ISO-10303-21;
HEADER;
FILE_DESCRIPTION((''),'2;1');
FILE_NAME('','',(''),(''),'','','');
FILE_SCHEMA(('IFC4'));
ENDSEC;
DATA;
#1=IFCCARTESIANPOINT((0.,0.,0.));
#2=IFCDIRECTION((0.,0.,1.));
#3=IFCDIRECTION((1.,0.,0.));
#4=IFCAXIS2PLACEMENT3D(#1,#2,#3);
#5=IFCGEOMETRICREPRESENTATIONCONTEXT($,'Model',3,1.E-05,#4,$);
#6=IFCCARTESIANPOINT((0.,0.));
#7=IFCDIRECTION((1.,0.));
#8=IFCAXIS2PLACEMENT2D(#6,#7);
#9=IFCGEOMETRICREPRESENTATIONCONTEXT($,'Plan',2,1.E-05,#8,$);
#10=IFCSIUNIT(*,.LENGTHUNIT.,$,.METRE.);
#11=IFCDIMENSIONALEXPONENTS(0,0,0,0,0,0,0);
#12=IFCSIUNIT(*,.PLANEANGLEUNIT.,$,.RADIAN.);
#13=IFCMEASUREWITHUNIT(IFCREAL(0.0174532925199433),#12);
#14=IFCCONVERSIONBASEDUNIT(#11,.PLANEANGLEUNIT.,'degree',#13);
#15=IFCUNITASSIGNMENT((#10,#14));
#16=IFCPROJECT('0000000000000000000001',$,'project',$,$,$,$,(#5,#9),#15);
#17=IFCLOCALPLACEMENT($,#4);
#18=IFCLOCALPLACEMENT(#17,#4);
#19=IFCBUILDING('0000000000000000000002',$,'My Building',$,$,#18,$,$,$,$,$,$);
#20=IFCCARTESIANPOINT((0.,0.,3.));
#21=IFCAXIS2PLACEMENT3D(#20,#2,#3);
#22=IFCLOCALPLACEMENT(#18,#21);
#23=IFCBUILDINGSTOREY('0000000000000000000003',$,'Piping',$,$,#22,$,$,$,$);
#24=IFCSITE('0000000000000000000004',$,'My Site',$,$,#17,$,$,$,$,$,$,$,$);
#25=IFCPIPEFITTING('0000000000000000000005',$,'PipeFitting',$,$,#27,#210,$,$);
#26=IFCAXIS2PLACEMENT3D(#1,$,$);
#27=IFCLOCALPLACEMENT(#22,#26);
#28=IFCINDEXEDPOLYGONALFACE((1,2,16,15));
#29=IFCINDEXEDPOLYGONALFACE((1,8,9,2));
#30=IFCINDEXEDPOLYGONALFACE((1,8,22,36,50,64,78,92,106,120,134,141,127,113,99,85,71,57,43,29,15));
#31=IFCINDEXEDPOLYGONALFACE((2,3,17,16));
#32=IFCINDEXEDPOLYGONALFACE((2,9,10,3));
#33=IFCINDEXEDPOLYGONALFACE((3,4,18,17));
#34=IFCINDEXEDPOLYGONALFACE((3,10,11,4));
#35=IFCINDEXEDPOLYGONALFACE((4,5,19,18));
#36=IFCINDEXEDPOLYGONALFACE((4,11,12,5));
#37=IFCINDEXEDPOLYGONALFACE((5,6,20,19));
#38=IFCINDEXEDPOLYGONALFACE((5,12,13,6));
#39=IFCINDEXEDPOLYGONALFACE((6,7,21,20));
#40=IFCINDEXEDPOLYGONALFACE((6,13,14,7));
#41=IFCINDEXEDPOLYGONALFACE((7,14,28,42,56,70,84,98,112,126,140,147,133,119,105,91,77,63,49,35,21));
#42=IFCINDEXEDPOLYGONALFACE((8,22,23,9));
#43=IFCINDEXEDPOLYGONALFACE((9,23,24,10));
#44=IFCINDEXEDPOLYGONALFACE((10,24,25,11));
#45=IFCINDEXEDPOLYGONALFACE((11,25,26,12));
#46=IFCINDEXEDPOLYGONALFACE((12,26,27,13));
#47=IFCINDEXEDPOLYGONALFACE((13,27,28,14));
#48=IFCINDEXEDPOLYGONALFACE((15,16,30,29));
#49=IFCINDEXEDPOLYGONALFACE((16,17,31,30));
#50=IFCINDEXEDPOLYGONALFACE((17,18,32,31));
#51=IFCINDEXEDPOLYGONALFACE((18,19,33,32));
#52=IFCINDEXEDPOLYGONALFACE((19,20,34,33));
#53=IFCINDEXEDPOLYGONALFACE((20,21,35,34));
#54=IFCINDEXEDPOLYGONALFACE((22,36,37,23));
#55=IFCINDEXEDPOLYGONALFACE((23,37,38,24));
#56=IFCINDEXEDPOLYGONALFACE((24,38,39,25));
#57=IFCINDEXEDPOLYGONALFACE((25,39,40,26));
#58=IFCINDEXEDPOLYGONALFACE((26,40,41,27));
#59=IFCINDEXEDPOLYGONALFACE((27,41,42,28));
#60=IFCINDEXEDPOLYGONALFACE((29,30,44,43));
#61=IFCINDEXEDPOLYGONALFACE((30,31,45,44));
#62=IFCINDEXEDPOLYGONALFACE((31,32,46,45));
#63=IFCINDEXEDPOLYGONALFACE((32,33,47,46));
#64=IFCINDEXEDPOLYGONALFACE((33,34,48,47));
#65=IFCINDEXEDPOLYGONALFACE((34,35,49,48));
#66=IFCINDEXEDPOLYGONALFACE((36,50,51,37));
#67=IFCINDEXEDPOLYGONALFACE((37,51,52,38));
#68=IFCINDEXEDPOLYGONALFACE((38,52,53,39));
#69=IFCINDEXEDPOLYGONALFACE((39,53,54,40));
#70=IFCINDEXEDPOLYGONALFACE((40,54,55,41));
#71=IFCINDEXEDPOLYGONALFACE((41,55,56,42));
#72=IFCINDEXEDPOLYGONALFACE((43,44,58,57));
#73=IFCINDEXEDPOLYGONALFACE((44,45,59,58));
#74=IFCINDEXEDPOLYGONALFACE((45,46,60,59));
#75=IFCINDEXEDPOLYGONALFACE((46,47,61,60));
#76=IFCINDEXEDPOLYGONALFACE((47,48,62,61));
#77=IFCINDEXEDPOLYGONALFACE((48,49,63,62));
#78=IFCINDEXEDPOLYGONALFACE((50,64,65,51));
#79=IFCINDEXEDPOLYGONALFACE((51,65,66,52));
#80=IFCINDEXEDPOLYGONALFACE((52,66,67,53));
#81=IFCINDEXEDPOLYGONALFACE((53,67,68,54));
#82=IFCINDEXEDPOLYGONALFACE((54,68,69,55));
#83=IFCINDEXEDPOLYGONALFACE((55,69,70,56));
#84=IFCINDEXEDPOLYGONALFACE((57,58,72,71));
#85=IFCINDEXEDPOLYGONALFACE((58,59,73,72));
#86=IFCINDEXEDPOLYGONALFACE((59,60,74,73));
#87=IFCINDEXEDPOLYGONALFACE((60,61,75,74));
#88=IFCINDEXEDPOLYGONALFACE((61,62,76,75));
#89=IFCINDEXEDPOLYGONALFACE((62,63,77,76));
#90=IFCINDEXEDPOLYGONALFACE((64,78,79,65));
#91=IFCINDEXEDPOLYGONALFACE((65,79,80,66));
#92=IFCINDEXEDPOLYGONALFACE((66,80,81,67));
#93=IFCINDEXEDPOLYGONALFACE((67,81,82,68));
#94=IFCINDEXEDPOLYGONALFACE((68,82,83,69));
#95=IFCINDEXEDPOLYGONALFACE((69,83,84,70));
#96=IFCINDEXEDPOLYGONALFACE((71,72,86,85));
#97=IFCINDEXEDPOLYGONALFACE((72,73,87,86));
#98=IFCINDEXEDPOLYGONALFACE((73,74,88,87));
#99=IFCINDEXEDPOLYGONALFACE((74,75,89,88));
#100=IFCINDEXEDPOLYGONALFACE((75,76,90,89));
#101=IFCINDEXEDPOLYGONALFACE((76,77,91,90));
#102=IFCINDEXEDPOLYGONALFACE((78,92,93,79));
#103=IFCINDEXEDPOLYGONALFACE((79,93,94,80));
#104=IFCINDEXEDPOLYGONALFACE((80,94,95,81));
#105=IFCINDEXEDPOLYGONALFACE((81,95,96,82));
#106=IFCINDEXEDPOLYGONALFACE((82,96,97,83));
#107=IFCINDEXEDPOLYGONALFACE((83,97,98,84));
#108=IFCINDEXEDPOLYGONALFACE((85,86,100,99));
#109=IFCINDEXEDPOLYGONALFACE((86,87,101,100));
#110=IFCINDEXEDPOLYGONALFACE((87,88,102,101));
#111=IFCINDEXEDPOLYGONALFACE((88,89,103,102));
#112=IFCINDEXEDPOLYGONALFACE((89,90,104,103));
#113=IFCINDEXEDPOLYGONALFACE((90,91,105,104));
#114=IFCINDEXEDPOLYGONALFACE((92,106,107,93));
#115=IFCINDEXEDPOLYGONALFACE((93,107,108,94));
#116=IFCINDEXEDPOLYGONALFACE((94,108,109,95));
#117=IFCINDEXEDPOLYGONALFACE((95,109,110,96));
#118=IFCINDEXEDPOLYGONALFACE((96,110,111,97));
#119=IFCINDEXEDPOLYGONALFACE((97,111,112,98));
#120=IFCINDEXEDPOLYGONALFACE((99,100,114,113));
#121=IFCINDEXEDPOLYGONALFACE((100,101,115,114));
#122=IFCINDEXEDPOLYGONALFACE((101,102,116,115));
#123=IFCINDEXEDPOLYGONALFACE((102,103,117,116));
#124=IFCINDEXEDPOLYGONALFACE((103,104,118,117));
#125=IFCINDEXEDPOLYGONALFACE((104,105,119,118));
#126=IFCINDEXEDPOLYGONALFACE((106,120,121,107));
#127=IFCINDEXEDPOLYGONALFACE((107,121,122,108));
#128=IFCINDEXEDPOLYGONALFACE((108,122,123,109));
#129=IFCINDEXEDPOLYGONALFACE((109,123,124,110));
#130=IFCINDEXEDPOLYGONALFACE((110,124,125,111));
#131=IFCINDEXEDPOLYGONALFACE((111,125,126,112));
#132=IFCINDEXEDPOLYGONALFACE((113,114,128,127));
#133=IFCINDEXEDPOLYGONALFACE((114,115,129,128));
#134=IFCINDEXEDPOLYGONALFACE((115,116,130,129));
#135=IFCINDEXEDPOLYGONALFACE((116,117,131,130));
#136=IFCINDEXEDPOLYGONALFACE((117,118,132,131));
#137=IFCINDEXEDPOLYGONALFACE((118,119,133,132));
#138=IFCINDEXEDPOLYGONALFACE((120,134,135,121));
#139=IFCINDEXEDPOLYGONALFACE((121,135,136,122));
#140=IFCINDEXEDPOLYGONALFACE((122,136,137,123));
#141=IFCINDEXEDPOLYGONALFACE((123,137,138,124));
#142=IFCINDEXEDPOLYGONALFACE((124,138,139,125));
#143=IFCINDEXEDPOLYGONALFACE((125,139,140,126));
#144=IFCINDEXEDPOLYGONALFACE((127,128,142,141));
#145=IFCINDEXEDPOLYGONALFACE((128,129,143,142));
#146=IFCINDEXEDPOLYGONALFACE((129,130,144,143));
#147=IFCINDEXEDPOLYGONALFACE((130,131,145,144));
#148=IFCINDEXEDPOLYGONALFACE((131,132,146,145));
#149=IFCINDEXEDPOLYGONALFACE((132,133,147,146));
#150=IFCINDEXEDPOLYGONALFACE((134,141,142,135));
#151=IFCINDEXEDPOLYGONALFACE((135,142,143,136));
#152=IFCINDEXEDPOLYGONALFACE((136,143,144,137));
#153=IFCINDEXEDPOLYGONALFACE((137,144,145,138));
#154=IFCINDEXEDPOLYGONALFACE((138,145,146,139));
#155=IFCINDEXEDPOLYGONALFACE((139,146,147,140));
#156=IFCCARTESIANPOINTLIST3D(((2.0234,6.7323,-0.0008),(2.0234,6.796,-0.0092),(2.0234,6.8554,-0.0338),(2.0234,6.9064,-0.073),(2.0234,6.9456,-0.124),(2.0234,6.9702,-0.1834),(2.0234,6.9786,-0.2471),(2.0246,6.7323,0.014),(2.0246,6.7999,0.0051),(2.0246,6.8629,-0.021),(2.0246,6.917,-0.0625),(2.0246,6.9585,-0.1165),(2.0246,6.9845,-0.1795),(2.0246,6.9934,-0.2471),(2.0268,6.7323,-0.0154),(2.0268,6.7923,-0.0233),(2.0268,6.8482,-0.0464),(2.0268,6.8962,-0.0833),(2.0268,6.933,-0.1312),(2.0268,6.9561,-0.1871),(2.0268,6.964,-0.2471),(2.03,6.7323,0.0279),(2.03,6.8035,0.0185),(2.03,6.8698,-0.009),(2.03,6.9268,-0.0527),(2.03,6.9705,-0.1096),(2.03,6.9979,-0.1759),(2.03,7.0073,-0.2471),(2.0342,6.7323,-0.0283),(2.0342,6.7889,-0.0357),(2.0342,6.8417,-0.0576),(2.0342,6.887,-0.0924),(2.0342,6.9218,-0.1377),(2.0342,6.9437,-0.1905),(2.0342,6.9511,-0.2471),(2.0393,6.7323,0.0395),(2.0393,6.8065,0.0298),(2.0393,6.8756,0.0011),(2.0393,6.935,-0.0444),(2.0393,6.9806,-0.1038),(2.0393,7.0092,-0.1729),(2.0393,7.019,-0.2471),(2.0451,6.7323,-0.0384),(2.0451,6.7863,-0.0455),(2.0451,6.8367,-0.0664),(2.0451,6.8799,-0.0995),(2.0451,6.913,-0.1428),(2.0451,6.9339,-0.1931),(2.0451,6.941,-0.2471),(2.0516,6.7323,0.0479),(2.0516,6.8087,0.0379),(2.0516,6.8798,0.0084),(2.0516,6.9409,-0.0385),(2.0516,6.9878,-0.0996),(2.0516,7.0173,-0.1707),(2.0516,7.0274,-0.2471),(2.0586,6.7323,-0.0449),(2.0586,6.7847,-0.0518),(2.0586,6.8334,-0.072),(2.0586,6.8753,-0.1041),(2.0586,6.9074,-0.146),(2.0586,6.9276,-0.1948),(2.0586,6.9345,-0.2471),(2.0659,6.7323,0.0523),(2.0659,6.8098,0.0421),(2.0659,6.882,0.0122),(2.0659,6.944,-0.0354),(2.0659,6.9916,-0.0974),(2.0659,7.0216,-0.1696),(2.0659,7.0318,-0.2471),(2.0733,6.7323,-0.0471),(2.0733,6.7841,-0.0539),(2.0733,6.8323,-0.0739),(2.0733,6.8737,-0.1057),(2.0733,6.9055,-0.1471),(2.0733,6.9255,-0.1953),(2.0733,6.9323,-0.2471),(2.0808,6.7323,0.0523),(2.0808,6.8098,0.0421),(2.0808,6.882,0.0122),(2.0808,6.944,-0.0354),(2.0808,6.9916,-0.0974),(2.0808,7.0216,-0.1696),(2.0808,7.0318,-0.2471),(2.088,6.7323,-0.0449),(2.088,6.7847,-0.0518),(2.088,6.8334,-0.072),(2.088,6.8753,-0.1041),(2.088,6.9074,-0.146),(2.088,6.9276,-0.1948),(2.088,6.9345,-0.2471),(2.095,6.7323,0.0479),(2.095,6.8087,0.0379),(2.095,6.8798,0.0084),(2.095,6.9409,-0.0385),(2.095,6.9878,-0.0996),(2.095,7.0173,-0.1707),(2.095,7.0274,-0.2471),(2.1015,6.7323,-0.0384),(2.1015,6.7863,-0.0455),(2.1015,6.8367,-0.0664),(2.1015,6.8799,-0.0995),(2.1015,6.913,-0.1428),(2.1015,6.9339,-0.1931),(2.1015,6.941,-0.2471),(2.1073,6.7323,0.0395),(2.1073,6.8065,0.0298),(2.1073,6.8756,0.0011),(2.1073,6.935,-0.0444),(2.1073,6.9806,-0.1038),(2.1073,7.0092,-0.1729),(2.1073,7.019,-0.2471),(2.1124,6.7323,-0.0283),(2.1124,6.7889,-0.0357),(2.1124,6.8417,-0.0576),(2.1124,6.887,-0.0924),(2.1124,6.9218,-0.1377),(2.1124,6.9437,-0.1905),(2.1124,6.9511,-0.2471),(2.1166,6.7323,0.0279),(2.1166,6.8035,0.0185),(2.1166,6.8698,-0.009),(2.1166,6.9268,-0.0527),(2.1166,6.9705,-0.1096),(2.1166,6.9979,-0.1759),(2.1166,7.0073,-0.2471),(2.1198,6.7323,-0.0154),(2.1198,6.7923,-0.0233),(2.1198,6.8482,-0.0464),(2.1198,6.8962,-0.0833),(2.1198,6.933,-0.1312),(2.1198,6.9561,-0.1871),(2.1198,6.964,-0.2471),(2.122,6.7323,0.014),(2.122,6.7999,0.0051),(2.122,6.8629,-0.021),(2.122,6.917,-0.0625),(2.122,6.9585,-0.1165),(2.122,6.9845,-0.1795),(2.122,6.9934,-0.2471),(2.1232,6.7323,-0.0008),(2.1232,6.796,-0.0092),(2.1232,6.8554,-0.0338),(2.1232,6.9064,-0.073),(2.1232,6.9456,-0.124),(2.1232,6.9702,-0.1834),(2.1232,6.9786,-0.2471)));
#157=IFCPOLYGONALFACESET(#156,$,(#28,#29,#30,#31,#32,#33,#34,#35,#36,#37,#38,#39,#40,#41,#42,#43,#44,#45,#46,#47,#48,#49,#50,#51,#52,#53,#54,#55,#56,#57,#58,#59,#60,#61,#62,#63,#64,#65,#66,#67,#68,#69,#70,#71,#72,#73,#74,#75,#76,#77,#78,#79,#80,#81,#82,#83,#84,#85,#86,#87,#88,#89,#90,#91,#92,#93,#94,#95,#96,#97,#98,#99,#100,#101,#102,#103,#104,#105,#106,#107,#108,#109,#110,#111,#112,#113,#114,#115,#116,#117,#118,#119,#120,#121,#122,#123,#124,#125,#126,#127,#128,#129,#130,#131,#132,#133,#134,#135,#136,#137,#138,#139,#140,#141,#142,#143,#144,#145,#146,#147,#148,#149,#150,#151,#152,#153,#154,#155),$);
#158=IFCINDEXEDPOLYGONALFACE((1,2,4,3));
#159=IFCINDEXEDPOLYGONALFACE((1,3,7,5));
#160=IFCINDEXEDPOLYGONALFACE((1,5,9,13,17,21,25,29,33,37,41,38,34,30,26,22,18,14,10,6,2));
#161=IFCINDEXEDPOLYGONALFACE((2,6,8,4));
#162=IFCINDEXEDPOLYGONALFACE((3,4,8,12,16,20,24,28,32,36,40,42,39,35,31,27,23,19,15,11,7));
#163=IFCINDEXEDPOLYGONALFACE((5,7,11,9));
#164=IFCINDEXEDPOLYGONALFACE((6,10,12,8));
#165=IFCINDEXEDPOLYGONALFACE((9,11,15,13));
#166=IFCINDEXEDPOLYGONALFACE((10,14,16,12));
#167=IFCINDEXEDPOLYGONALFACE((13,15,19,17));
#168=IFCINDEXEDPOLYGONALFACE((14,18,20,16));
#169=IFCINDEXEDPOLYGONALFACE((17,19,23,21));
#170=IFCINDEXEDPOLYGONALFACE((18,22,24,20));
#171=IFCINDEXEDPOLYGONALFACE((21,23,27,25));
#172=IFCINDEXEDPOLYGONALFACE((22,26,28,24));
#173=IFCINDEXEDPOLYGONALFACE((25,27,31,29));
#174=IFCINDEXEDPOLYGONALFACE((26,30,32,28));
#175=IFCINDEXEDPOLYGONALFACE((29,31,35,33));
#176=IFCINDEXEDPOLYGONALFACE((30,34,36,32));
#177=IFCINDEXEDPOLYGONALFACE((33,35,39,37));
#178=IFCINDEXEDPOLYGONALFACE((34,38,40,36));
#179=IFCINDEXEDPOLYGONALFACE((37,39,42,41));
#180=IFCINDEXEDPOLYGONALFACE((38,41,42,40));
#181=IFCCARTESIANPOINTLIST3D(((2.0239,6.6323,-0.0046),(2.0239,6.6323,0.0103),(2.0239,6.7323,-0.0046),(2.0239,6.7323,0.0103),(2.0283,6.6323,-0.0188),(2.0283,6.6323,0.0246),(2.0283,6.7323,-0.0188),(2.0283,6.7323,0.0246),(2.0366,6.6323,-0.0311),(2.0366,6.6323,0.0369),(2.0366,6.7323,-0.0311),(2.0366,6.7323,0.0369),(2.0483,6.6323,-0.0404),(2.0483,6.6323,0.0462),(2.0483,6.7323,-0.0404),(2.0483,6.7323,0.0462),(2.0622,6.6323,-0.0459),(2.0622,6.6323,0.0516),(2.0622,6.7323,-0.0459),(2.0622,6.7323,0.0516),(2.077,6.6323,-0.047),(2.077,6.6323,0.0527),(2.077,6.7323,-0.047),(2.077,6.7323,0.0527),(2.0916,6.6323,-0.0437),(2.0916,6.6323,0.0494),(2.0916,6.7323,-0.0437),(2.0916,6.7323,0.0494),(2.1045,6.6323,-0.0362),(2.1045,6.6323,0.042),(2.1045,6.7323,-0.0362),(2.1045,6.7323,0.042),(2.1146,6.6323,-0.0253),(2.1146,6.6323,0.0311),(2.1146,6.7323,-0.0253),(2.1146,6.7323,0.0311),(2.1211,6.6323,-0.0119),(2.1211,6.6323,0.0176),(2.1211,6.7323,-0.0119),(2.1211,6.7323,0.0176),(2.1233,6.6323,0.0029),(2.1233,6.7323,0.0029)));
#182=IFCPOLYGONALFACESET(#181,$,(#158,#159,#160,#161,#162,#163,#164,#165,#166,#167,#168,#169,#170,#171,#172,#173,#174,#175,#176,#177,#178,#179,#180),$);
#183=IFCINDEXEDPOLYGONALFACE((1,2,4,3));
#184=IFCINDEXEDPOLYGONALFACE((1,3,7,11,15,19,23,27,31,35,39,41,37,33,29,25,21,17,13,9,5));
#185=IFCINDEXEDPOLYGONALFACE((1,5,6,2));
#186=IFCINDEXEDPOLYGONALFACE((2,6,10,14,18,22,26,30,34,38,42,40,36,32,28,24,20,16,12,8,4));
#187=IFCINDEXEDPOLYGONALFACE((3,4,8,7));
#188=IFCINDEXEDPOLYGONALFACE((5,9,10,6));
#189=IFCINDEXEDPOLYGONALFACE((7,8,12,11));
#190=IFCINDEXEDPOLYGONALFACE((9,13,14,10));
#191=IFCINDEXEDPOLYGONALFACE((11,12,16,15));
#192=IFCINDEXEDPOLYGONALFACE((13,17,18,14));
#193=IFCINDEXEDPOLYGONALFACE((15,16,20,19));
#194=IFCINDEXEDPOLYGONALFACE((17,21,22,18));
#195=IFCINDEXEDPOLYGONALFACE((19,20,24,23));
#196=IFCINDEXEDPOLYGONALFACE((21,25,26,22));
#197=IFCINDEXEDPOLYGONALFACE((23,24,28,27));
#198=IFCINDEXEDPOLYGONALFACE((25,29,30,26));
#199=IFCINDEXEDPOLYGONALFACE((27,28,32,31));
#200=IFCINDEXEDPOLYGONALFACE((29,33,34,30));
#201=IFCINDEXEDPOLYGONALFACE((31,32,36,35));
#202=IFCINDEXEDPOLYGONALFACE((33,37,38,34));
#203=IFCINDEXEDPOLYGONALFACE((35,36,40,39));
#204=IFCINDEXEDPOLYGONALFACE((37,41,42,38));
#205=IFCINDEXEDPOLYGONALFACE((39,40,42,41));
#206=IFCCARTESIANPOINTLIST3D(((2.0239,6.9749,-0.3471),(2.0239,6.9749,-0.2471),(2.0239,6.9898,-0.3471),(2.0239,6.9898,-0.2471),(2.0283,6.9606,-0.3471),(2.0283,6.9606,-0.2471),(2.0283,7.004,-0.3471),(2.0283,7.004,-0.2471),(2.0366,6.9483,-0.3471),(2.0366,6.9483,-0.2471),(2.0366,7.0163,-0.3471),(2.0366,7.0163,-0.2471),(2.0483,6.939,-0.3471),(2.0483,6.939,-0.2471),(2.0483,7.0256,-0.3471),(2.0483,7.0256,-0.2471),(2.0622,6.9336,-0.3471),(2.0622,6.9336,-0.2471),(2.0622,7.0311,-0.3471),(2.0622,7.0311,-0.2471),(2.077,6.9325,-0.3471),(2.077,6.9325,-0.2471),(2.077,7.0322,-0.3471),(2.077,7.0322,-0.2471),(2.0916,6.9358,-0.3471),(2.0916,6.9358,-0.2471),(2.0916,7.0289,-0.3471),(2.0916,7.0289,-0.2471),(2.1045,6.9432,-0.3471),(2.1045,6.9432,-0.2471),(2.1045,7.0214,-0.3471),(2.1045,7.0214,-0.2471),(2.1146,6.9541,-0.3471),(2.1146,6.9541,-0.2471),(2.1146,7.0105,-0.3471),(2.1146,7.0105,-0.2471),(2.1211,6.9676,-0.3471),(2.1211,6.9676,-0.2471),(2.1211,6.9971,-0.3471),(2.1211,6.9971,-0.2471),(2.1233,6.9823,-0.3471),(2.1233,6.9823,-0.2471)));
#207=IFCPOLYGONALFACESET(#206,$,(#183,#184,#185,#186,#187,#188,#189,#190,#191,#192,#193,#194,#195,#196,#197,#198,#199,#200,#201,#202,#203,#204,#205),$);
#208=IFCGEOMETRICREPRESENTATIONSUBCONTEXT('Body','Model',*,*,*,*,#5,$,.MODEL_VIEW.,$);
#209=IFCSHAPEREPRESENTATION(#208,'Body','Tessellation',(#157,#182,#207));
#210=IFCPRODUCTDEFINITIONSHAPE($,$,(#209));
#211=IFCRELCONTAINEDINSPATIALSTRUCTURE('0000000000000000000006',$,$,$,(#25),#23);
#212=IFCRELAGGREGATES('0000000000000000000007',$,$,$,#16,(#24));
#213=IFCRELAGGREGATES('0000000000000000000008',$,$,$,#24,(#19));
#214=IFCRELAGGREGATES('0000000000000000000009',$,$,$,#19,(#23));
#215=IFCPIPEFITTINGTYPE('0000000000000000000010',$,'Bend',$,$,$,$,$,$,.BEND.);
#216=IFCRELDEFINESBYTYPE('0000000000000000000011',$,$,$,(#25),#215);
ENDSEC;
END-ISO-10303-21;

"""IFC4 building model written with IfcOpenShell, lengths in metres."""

from ifc_helpers import new_model, entity, si_unit, converted_unit, frame, origin_with_axes, origin_2d_with_axis, place, context, subcontext, project, spatial, circle, extrude, source, transform, mapped, type_object, type_shapes, element, save


model = new_model("IFC4")

# Units and contexts
model_context = context("Model", 3, precision=1e-05, world=origin_with_axes())
plan_context = context("Plan", 2, precision=1e-05, world=origin_2d_with_axis())
body_context = subcontext(model_context, "Body", "Model", "MODEL_VIEW")
ifc_project = project(units=[si_unit("LENGTHUNIT", "METRE"), converted_unit("PLANEANGLEUNIT", "degree", entity("IfcReal", 0.0174532925199433), si_unit("PLANEANGLEUNIT", "RADIAN"), dimensions=[0, 0, 0, 0, 0, 0, 0])], contexts=[model_context, plan_context])

# Site, building, storey
site_placement = place(None, origin_with_axes())
site = spatial("IfcSite", under=ifc_project, at=site_placement, Name="My Site")
building_placement = place(site_placement, origin_with_axes())
building = spatial("IfcBuilding", under=site, at=building_placement, Name="My Building")
storey_placement = place(building_placement, frame((0.0, 0.0, 3.0), z_axis=(0.0, 0.0, 1.0), x_axis=(1.0, 0.0, 0.0)))
storey = spatial("IfcBuildingStorey", under=building, at=storey_placement, Name="Piping")

# Pipe fitting
pipe_fitting_type_1 = type_object("IfcPipeFittingType", Name="Bend", PredefinedType="BEND")
shared_shape = source(origin_with_axes(), body_context, "Body", "SolidModel", [
    entity("IfcSweptDiskSolid", entity("IfcIndexedPolyCurve", entity("IfcCartesianPointList3D", [[0.0, 0.0, -0.1], [0.0, -0.0732, -0.2768], [0.0, -0.25, -0.35]]), [entity("IfcArcIndex", [1, 2, 3])]), 0.05),
    extrude(circle(Radius=0.05), origin_with_axes(), (0.0, 0.0, -1.0), 0.1),
    extrude(circle(Radius=0.05), frame((0.0, -0.25, -0.35), z_axis=(0.0, -1.0, 0.0), x_axis=(1.0, 0.0, 0.0)), (0.0, 0.0, 1.0), 0.1),
])
type_shapes(pipe_fitting_type_1, [shared_shape])
for number, where, z_axis, x_axis, name in (
    (1, (2.0733, 6.6323, 0.0029), (0.0, -1.0, 0.0), (1.0, 0.0, 0.0), "PipeFitting"),
):
    element("IfcPipeFitting", number, at=place(storey_placement, frame(where, z_axis=z_axis, x_axis=x_axis)), inside=storey, type_object=pipe_fitting_type_1, Name=name, context=body_context, shape_type="MappedRepresentation", body=[
        mapped(shared_shape, transform((0.0, 0.0, 0.0), x_axis=(1.0, 0.0, 0.0), y_axis=(0.0, 1.0, 0.0), z_axis=(0.0, 0.0, 1.0), scale=1.0)),
    ])

save(model, "model.ifc")
